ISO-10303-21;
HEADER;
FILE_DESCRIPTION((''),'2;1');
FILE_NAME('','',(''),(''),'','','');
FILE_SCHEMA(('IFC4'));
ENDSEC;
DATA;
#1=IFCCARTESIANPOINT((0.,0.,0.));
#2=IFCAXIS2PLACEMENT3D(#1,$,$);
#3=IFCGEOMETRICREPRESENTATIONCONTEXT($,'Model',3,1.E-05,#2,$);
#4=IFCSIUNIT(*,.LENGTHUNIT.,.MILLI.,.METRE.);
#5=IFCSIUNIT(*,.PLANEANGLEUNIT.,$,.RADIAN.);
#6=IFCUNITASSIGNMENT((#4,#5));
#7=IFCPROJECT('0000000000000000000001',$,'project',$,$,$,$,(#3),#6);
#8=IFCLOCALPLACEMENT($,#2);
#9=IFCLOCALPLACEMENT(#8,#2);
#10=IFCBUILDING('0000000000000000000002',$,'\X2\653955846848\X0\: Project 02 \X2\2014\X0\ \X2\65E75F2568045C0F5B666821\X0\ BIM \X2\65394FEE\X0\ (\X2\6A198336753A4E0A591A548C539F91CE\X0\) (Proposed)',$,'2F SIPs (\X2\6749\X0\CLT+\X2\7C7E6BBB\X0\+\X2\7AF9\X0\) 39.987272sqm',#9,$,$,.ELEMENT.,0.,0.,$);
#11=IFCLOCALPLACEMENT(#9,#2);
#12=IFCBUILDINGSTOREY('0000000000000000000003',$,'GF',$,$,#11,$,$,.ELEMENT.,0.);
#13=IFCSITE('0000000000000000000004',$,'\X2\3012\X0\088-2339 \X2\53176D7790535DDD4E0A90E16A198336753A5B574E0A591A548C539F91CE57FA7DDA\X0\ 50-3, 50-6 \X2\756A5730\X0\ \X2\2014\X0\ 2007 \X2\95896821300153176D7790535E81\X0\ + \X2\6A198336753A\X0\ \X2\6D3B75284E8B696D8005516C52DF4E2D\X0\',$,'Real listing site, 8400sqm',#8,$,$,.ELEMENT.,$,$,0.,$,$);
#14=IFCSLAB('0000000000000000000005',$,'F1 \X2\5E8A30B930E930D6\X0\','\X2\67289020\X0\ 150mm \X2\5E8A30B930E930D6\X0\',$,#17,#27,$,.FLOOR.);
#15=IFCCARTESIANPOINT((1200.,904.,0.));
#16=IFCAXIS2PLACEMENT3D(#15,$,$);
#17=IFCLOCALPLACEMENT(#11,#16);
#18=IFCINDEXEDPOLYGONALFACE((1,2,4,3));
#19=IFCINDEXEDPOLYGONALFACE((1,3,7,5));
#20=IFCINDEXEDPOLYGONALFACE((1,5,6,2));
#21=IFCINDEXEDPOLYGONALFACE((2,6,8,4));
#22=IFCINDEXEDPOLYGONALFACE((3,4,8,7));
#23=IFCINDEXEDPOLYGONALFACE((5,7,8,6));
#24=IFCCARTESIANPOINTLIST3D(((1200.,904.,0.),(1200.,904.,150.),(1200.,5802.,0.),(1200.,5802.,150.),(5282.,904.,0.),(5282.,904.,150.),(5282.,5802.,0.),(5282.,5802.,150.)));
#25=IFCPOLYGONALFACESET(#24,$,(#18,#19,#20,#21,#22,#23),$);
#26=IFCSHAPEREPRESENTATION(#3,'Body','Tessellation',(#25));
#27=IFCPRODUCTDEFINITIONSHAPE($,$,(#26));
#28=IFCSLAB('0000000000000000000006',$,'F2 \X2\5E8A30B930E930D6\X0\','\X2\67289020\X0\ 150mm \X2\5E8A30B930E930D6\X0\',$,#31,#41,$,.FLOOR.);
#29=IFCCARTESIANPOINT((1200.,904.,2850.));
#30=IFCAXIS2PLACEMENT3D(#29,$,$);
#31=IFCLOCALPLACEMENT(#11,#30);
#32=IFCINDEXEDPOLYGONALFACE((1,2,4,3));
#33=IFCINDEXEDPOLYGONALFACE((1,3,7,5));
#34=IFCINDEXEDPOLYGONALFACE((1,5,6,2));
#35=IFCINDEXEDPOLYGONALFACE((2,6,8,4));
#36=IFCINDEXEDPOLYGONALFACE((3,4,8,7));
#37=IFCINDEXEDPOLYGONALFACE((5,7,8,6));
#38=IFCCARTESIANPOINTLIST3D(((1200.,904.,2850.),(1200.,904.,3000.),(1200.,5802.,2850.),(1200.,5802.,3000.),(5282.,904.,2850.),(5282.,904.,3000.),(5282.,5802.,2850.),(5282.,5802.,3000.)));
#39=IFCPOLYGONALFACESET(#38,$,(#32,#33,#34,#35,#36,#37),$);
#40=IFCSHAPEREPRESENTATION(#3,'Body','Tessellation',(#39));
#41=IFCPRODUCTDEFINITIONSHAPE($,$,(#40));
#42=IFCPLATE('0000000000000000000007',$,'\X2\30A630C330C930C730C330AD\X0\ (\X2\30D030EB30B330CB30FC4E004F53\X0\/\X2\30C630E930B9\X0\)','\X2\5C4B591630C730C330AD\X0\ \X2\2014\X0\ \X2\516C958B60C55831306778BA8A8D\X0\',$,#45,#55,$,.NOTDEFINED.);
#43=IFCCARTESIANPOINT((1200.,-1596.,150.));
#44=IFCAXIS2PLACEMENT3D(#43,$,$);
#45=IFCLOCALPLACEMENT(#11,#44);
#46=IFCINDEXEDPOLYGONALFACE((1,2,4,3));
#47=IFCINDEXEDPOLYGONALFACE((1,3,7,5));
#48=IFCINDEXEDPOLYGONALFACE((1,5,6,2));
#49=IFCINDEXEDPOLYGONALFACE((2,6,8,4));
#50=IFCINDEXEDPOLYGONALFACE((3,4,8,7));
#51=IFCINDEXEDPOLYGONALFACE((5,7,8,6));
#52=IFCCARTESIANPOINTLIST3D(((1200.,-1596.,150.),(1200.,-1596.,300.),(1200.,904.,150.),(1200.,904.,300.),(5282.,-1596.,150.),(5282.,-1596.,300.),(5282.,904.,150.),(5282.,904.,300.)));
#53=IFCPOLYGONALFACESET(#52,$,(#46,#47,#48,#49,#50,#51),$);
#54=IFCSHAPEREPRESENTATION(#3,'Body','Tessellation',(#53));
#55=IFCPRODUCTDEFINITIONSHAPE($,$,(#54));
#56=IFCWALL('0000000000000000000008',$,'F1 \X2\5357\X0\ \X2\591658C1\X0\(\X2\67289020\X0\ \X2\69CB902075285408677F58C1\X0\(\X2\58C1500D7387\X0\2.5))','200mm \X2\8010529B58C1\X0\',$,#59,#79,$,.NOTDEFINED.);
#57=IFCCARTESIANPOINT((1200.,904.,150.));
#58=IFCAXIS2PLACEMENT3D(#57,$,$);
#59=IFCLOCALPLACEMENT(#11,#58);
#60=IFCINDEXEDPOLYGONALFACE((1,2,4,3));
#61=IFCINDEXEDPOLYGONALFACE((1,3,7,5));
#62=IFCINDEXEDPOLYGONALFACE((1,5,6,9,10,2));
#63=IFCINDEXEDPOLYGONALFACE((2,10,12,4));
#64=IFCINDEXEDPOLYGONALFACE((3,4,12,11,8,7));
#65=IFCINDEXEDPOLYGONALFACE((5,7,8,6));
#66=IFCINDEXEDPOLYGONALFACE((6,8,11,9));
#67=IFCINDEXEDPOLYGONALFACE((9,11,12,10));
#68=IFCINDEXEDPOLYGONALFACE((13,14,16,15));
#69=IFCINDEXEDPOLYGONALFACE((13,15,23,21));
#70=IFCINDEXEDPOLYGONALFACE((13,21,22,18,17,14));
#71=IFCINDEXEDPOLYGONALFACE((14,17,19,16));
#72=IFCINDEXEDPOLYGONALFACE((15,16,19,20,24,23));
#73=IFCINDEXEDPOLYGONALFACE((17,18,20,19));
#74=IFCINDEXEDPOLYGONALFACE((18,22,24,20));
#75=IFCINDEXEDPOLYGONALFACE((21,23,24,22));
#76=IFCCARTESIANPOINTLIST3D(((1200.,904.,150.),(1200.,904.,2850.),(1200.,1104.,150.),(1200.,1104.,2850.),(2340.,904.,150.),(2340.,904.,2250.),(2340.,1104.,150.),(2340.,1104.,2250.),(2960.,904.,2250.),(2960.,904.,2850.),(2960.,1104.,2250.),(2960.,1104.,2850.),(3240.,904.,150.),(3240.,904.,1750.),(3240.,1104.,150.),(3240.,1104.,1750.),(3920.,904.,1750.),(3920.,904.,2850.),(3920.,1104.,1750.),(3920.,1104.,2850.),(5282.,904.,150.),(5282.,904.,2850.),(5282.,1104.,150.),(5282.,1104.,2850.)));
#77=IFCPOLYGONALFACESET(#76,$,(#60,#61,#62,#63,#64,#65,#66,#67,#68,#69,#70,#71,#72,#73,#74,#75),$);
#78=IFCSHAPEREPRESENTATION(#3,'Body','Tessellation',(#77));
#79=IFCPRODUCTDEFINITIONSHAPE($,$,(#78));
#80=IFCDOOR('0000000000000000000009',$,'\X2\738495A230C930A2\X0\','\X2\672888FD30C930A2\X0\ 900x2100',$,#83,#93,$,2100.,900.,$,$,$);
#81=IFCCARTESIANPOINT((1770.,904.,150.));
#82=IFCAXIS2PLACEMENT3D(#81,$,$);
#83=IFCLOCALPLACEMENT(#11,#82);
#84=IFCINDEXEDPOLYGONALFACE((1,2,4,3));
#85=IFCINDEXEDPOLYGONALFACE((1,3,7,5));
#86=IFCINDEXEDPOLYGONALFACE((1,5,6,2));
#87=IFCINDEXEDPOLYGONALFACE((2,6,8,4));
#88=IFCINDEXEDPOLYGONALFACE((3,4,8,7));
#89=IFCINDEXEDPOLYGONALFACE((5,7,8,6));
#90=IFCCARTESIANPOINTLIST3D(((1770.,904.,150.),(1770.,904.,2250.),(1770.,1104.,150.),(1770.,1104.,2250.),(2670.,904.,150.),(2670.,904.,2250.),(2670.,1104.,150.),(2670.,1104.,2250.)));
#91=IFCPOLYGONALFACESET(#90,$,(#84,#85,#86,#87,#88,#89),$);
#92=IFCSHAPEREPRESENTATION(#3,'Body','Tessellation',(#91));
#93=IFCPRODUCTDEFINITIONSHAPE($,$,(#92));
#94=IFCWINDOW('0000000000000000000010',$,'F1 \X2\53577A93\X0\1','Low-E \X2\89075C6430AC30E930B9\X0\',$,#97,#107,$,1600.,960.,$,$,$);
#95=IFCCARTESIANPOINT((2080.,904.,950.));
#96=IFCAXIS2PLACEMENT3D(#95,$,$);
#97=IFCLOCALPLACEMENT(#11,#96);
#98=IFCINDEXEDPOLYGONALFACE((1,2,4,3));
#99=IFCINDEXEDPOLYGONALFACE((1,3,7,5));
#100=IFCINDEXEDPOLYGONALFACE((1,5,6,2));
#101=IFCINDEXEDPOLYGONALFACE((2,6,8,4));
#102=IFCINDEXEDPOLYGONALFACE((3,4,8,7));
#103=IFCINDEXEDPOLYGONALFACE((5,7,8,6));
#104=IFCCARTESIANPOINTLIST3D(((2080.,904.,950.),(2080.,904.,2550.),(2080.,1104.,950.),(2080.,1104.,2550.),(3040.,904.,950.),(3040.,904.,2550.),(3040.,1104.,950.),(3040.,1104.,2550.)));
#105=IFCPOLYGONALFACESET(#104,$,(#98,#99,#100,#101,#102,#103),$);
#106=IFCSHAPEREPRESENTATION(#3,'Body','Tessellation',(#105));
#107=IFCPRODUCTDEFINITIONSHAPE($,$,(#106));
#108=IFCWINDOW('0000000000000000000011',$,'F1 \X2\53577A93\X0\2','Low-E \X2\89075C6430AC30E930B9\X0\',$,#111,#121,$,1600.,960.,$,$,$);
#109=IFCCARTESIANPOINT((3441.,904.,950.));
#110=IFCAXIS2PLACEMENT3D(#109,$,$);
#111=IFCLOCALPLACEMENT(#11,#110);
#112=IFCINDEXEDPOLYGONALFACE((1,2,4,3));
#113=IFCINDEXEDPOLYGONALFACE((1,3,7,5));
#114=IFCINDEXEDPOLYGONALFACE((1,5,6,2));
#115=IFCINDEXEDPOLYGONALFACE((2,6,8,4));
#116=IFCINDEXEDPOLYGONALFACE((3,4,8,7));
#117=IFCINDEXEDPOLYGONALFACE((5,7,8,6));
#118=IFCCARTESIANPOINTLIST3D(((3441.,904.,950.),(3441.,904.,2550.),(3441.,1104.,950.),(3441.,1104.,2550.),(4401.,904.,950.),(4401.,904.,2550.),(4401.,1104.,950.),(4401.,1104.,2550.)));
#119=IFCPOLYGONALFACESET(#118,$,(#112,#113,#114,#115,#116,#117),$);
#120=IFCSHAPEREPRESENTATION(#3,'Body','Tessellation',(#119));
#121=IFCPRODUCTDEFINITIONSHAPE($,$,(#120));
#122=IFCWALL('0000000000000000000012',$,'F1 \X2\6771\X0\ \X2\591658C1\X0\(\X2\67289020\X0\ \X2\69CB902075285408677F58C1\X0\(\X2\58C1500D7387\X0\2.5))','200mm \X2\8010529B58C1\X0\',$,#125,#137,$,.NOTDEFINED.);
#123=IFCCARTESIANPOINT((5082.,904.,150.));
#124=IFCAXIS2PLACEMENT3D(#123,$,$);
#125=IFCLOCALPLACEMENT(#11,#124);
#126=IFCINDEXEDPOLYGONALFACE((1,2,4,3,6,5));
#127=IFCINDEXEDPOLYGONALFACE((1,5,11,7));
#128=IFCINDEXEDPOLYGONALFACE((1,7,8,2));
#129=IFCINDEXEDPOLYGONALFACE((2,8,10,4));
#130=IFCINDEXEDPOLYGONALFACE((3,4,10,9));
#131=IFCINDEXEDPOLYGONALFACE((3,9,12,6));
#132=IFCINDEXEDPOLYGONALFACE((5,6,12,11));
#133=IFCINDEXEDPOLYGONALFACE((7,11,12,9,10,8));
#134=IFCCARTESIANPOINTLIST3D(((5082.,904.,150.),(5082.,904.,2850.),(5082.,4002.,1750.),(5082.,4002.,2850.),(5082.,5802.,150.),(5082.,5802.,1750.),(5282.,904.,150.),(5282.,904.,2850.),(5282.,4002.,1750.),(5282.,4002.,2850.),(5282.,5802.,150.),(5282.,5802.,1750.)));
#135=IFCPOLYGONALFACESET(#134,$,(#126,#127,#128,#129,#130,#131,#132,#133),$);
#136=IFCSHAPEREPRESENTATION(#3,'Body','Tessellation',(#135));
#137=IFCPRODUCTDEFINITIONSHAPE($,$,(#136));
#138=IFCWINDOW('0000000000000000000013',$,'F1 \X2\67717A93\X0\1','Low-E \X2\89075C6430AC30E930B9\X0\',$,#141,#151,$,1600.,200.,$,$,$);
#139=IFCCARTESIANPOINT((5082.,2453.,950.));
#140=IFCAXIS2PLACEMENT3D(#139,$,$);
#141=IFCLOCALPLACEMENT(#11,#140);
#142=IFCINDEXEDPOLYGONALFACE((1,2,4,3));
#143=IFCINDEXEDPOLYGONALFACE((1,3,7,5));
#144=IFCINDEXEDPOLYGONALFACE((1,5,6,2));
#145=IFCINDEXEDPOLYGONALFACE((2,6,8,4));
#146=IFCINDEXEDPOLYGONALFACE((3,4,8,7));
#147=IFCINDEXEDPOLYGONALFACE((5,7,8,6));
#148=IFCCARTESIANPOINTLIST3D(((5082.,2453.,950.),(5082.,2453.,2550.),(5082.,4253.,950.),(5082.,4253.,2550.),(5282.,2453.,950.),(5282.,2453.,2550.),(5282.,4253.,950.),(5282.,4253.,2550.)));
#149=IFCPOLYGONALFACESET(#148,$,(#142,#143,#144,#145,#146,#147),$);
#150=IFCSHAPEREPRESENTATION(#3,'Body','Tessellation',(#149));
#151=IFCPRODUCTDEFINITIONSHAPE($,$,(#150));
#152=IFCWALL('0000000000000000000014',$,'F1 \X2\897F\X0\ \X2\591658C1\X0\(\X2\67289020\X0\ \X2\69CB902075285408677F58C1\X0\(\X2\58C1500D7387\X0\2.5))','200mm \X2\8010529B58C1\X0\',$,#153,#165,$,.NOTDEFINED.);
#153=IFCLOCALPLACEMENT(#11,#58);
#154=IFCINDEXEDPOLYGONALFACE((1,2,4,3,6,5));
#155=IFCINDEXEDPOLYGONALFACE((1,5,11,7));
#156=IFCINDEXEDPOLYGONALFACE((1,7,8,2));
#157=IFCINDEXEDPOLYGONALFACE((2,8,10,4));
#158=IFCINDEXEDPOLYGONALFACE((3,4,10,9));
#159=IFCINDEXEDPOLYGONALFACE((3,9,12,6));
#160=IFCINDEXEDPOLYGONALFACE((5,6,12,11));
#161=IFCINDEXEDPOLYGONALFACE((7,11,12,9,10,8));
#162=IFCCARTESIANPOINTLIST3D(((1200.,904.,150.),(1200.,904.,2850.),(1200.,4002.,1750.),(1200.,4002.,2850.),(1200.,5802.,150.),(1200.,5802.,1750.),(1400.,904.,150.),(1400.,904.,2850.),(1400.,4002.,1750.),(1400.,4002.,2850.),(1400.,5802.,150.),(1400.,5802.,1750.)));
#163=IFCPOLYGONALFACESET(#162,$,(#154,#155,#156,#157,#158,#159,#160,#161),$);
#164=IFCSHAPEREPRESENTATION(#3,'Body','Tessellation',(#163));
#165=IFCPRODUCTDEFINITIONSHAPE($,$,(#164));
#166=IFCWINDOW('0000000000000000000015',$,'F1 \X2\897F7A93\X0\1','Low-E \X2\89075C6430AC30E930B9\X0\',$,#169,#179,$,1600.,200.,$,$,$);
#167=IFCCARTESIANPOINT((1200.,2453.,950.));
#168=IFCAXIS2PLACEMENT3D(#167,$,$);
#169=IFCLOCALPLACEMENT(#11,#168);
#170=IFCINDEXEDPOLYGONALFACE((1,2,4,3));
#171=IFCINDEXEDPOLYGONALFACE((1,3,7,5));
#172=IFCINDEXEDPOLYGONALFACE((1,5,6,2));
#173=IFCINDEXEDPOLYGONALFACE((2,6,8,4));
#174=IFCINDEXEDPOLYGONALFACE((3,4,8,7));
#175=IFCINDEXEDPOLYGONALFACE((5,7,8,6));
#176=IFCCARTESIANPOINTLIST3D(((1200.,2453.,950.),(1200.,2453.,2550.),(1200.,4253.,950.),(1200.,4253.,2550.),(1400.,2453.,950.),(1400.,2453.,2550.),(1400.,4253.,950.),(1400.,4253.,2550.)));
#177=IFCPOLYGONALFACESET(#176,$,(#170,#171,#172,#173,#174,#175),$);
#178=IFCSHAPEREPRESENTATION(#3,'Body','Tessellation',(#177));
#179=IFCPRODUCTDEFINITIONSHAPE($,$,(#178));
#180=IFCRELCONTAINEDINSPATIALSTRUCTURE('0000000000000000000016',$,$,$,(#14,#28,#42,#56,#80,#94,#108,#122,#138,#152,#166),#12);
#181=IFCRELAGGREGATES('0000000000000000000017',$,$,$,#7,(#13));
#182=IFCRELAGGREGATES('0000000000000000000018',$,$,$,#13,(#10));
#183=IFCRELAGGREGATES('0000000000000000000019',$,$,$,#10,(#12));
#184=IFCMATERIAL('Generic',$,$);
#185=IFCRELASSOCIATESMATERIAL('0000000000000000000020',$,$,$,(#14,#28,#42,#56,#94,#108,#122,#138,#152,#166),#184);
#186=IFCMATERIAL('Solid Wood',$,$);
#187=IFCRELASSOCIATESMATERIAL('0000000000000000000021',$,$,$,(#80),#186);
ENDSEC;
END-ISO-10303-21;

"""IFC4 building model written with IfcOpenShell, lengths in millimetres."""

from ifc_helpers import new_model, si_unit, frame, frame_2d, origin, place, context, project, spatial, rectangle, extrude, material, element, fill, save


model = new_model("IFC4")

# Units and contexts
model_context = context("Model", 3, precision=1e-05, world=origin())
ifc_project = project(units=[si_unit("LENGTHUNIT", "METRE", prefix="MILLI"), si_unit("PLANEANGLEUNIT", "RADIAN")], contexts=[model_context])

# Site, building, storey
site_placement = place(None, origin())
site = spatial("IfcSite", under=ifc_project, at=site_placement, Name="〒088-2339 北海道川上郡標茶町字上多和原野基線 50-3, 50-6 番地 — 2007 閉校、北海道庁 + 標茶町 活用事業者公募中", ObjectType="Real listing site, 8400sqm", CompositionType="ELEMENT", RefElevation=0.0)
building_placement = place(site_placement, origin())
building = spatial("IfcBuilding", under=site, at=building_placement, Name="改善案: Project 02 — 旧弥栄小学校 BIM 改修 (標茶町上多和原野) (Proposed)", ObjectType="2F SIPs (杉CLT+籾殻+竹) 39.987272sqm", CompositionType="ELEMENT", ElevationOfRefHeight=0.0, ElevationOfTerrain=0.0)
storey_placement = place(building_placement, origin())
storey = spatial("IfcBuildingStorey", under=building, at=storey_placement, Name="GF", CompositionType="ELEMENT", Elevation=0.0)

# Slabs
ifc_material_1 = material(Name="Generic")
slab_1_placement = place(storey_placement, frame((1200.0, 904.0, 0.0)))
element("IfcSlab", 1, at=slab_1_placement, inside=storey, material=ifc_material_1, Name="F1 床スラブ", Description="木造 150mm 床スラブ", PredefinedType="FLOOR", context=model_context, shape_type="SweptSolid", body=[
    extrude(rectangle(XDim=4082.0, YDim=4898.0, at=frame_2d((2041.0, 2449.0))), frame((1200.0, 904.0, 0.0)), (0.0, 0.0, 1.0), 150.0),
])
slab_2_placement = place(storey_placement, frame((1200.0, 904.0, 2850.0)))
element("IfcSlab", 2, at=slab_2_placement, inside=storey, material=ifc_material_1, Name="F2 床スラブ", Description="木造 150mm 床スラブ", PredefinedType="FLOOR", context=model_context, shape_type="SweptSolid", body=[
    extrude(rectangle(XDim=4082.0, YDim=4898.0, at=frame_2d((2041.0, 2449.0))), frame((1200.0, 904.0, 2850.0)), (0.0, 0.0, 1.0), 150.0),
])

# Plate
plate_placement = place(storey_placement, frame((1200.0, -1596.0, 150.0)))
element("IfcPlate", 3, at=plate_placement, inside=storey, material=ifc_material_1, Name="ウッドデッキ (バルコニー一体/テラス)", Description="屋外デッキ — 公開情報で確認", PredefinedType="NOTDEFINED", context=model_context, shape_type="SweptSolid", body=[
    extrude(rectangle(XDim=4082.0, YDim=2500.0, at=frame_2d((2041.0, 1250.0))), frame((1200.0, -1596.0, 150.0)), (0.0, 0.0, 1.0), 150.0),
])

# Wall, openings, door, windows
wall_1_placement = place(storey_placement, frame((1200.0, 904.0, 150.0)))
wall_1 = element("IfcWall", 4, at=wall_1_placement, inside=storey, material=ifc_material_1, Name="F1 南 外壁(木造 構造用合板壁(壁倍率2.5))", Description="200mm 耐力壁", PredefinedType="NOTDEFINED", context=model_context, shape_type="SweptSolid", body=[
    extrude(rectangle(XDim=4082.0, YDim=200.0, at=frame_2d((2041.0, 100.0))), frame((1200.0, 904.0, 150.0)), (0.0, 0.0, 1.0), 2700.0),
])
opening_1_placement = place(storey_placement, frame((1770.0, 904.0, 150.0)))
opening_1 = element("IfcOpeningElement", 5, at=opening_1_placement, cuts=wall_1, PredefinedType="NOTDEFINED", context=model_context, shape_type="SweptSolid", body=[
    extrude(rectangle(XDim=900.0, YDim=200.0, at=frame_2d((450.0, 100.0))), frame((1770.0, 904.0, 150.0)), (0.0, 0.0, 1.0), 2100.0),
])
opening_2_placement = place(storey_placement, frame((2080.0, 904.0, 950.0)))
opening_2 = element("IfcOpeningElement", 6, at=opening_2_placement, cuts=wall_1, PredefinedType="NOTDEFINED", context=model_context, shape_type="SweptSolid", body=[
    extrude(rectangle(XDim=960.0, YDim=200.0, at=frame_2d((480.0, 100.0))), frame((2080.0, 904.0, 950.0)), (0.0, 0.0, 1.0), 1600.0),
])
opening_3_placement = place(storey_placement, frame((3441.0, 904.0, 950.0)))
opening_3 = element("IfcOpeningElement", 7, at=opening_3_placement, cuts=wall_1, PredefinedType="NOTDEFINED", context=model_context, shape_type="SweptSolid", body=[
    extrude(rectangle(XDim=960.0, YDim=200.0, at=frame_2d((480.0, 100.0))), frame((3441.0, 904.0, 950.0)), (0.0, 0.0, 1.0), 1600.0),
])
ifc_material_2 = material(Name="Solid Wood")
door_placement = place(storey_placement, frame((1770.0, 904.0, 150.0)))
door = element("IfcDoor", 8, at=door_placement, inside=storey, material=ifc_material_2, Name="玄関ドア", Description="木製ドア 900x2100", OverallHeight=2100.0, OverallWidth=900.0, context=model_context, shape_type="SweptSolid", body=[
    extrude(rectangle(XDim=900.0, YDim=200.0, at=frame_2d((450.0, 100.0))), frame((1770.0, 904.0, 150.0)), (0.0, 0.0, 1.0), 2100.0),
])
fill(opening_1, door)
window_1_placement = place(storey_placement, frame((2080.0, 904.0, 950.0)))
window_1 = element("IfcWindow", 9, at=window_1_placement, inside=storey, material=ifc_material_1, Name="F1 南窓1", Description="Low-E 複層ガラス", OverallHeight=1600.0, OverallWidth=960.0, context=model_context, shape_type="SweptSolid", body=[
    extrude(rectangle(XDim=960.0, YDim=200.0, at=frame_2d((480.0, 100.0))), frame((2080.0, 904.0, 950.0)), (0.0, 0.0, 1.0), 1600.0),
])
fill(opening_2, window_1)
window_2_placement = place(storey_placement, frame((3441.0, 904.0, 950.0)))
window_2 = element("IfcWindow", 10, at=window_2_placement, inside=storey, material=ifc_material_1, Name="F1 南窓2", Description="Low-E 複層ガラス", OverallHeight=1600.0, OverallWidth=960.0, context=model_context, shape_type="SweptSolid", body=[
    extrude(rectangle(XDim=960.0, YDim=200.0, at=frame_2d((480.0, 100.0))), frame((3441.0, 904.0, 950.0)), (0.0, 0.0, 1.0), 1600.0),
])
fill(opening_3, window_2)

# Walls, openings, windows
wall_2_placement = place(storey_placement, frame((5082.0, 904.0, 150.0)))
wall_2 = element("IfcWall", 11, at=wall_2_placement, inside=storey, material=ifc_material_1, Name="F1 東 外壁(木造 構造用合板壁(壁倍率2.5))", Description="200mm 耐力壁", PredefinedType="NOTDEFINED", context=model_context, shape_type="SweptSolid", body=[
    extrude(rectangle(XDim=200.0, YDim=4898.0, at=frame_2d((100.0, 2449.0))), frame((5082.0, 904.0, 150.0)), (0.0, 0.0, 1.0), 2700.0),
])
opening_4_placement = place(storey_placement, frame((5082.0, 2453.0, 950.0)))
opening_4 = element("IfcOpeningElement", 12, at=opening_4_placement, cuts=wall_2, PredefinedType="NOTDEFINED", context=model_context, shape_type="SweptSolid", body=[
    extrude(rectangle(XDim=200.0, YDim=1800.0, at=frame_2d((100.0, 900.0))), frame((5082.0, 2453.0, 950.0)), (0.0, 0.0, 1.0), 1600.0),
])
window_3_placement = place(storey_placement, frame((5082.0, 2453.0, 950.0)))
window_3 = element("IfcWindow", 13, at=window_3_placement, inside=storey, material=ifc_material_1, Name="F1 東窓1", Description="Low-E 複層ガラス", OverallHeight=1600.0, OverallWidth=200.0, context=model_context, shape_type="SweptSolid", body=[
    extrude(rectangle(XDim=200.0, YDim=1800.0, at=frame_2d((100.0, 900.0))), frame((5082.0, 2453.0, 950.0)), (0.0, 0.0, 1.0), 1600.0),
])
fill(opening_4, window_3)
wall_3_placement = place(storey_placement, frame((1200.0, 904.0, 150.0)))
wall_3 = element("IfcWall", 14, at=wall_3_placement, inside=storey, material=ifc_material_1, Name="F1 西 外壁(木造 構造用合板壁(壁倍率2.5))", Description="200mm 耐力壁", PredefinedType="NOTDEFINED", context=model_context, shape_type="SweptSolid", body=[
    extrude(rectangle(XDim=200.0, YDim=4898.0, at=frame_2d((100.0, 2449.0))), frame((1200.0, 904.0, 150.0)), (0.0, 0.0, 1.0), 2700.0),
])
opening_5_placement = place(storey_placement, frame((1200.0, 2453.0, 950.0)))
opening_5 = element("IfcOpeningElement", 15, at=opening_5_placement, cuts=wall_3, PredefinedType="NOTDEFINED", context=model_context, shape_type="SweptSolid", body=[
    extrude(rectangle(XDim=200.0, YDim=1800.0, at=frame_2d((100.0, 900.0))), frame((1200.0, 2453.0, 950.0)), (0.0, 0.0, 1.0), 1600.0),
])
window_4_placement = place(storey_placement, frame((1200.0, 2453.0, 950.0)))
window_4 = element("IfcWindow", 16, at=window_4_placement, inside=storey, material=ifc_material_1, Name="F1 西窓1", Description="Low-E 複層ガラス", OverallHeight=1600.0, OverallWidth=200.0, context=model_context, shape_type="SweptSolid", body=[
    extrude(rectangle(XDim=200.0, YDim=1800.0, at=frame_2d((100.0, 900.0))), frame((1200.0, 2453.0, 950.0)), (0.0, 0.0, 1.0), 1600.0),
])
fill(opening_5, window_4)

save(model, "model.ifc")
